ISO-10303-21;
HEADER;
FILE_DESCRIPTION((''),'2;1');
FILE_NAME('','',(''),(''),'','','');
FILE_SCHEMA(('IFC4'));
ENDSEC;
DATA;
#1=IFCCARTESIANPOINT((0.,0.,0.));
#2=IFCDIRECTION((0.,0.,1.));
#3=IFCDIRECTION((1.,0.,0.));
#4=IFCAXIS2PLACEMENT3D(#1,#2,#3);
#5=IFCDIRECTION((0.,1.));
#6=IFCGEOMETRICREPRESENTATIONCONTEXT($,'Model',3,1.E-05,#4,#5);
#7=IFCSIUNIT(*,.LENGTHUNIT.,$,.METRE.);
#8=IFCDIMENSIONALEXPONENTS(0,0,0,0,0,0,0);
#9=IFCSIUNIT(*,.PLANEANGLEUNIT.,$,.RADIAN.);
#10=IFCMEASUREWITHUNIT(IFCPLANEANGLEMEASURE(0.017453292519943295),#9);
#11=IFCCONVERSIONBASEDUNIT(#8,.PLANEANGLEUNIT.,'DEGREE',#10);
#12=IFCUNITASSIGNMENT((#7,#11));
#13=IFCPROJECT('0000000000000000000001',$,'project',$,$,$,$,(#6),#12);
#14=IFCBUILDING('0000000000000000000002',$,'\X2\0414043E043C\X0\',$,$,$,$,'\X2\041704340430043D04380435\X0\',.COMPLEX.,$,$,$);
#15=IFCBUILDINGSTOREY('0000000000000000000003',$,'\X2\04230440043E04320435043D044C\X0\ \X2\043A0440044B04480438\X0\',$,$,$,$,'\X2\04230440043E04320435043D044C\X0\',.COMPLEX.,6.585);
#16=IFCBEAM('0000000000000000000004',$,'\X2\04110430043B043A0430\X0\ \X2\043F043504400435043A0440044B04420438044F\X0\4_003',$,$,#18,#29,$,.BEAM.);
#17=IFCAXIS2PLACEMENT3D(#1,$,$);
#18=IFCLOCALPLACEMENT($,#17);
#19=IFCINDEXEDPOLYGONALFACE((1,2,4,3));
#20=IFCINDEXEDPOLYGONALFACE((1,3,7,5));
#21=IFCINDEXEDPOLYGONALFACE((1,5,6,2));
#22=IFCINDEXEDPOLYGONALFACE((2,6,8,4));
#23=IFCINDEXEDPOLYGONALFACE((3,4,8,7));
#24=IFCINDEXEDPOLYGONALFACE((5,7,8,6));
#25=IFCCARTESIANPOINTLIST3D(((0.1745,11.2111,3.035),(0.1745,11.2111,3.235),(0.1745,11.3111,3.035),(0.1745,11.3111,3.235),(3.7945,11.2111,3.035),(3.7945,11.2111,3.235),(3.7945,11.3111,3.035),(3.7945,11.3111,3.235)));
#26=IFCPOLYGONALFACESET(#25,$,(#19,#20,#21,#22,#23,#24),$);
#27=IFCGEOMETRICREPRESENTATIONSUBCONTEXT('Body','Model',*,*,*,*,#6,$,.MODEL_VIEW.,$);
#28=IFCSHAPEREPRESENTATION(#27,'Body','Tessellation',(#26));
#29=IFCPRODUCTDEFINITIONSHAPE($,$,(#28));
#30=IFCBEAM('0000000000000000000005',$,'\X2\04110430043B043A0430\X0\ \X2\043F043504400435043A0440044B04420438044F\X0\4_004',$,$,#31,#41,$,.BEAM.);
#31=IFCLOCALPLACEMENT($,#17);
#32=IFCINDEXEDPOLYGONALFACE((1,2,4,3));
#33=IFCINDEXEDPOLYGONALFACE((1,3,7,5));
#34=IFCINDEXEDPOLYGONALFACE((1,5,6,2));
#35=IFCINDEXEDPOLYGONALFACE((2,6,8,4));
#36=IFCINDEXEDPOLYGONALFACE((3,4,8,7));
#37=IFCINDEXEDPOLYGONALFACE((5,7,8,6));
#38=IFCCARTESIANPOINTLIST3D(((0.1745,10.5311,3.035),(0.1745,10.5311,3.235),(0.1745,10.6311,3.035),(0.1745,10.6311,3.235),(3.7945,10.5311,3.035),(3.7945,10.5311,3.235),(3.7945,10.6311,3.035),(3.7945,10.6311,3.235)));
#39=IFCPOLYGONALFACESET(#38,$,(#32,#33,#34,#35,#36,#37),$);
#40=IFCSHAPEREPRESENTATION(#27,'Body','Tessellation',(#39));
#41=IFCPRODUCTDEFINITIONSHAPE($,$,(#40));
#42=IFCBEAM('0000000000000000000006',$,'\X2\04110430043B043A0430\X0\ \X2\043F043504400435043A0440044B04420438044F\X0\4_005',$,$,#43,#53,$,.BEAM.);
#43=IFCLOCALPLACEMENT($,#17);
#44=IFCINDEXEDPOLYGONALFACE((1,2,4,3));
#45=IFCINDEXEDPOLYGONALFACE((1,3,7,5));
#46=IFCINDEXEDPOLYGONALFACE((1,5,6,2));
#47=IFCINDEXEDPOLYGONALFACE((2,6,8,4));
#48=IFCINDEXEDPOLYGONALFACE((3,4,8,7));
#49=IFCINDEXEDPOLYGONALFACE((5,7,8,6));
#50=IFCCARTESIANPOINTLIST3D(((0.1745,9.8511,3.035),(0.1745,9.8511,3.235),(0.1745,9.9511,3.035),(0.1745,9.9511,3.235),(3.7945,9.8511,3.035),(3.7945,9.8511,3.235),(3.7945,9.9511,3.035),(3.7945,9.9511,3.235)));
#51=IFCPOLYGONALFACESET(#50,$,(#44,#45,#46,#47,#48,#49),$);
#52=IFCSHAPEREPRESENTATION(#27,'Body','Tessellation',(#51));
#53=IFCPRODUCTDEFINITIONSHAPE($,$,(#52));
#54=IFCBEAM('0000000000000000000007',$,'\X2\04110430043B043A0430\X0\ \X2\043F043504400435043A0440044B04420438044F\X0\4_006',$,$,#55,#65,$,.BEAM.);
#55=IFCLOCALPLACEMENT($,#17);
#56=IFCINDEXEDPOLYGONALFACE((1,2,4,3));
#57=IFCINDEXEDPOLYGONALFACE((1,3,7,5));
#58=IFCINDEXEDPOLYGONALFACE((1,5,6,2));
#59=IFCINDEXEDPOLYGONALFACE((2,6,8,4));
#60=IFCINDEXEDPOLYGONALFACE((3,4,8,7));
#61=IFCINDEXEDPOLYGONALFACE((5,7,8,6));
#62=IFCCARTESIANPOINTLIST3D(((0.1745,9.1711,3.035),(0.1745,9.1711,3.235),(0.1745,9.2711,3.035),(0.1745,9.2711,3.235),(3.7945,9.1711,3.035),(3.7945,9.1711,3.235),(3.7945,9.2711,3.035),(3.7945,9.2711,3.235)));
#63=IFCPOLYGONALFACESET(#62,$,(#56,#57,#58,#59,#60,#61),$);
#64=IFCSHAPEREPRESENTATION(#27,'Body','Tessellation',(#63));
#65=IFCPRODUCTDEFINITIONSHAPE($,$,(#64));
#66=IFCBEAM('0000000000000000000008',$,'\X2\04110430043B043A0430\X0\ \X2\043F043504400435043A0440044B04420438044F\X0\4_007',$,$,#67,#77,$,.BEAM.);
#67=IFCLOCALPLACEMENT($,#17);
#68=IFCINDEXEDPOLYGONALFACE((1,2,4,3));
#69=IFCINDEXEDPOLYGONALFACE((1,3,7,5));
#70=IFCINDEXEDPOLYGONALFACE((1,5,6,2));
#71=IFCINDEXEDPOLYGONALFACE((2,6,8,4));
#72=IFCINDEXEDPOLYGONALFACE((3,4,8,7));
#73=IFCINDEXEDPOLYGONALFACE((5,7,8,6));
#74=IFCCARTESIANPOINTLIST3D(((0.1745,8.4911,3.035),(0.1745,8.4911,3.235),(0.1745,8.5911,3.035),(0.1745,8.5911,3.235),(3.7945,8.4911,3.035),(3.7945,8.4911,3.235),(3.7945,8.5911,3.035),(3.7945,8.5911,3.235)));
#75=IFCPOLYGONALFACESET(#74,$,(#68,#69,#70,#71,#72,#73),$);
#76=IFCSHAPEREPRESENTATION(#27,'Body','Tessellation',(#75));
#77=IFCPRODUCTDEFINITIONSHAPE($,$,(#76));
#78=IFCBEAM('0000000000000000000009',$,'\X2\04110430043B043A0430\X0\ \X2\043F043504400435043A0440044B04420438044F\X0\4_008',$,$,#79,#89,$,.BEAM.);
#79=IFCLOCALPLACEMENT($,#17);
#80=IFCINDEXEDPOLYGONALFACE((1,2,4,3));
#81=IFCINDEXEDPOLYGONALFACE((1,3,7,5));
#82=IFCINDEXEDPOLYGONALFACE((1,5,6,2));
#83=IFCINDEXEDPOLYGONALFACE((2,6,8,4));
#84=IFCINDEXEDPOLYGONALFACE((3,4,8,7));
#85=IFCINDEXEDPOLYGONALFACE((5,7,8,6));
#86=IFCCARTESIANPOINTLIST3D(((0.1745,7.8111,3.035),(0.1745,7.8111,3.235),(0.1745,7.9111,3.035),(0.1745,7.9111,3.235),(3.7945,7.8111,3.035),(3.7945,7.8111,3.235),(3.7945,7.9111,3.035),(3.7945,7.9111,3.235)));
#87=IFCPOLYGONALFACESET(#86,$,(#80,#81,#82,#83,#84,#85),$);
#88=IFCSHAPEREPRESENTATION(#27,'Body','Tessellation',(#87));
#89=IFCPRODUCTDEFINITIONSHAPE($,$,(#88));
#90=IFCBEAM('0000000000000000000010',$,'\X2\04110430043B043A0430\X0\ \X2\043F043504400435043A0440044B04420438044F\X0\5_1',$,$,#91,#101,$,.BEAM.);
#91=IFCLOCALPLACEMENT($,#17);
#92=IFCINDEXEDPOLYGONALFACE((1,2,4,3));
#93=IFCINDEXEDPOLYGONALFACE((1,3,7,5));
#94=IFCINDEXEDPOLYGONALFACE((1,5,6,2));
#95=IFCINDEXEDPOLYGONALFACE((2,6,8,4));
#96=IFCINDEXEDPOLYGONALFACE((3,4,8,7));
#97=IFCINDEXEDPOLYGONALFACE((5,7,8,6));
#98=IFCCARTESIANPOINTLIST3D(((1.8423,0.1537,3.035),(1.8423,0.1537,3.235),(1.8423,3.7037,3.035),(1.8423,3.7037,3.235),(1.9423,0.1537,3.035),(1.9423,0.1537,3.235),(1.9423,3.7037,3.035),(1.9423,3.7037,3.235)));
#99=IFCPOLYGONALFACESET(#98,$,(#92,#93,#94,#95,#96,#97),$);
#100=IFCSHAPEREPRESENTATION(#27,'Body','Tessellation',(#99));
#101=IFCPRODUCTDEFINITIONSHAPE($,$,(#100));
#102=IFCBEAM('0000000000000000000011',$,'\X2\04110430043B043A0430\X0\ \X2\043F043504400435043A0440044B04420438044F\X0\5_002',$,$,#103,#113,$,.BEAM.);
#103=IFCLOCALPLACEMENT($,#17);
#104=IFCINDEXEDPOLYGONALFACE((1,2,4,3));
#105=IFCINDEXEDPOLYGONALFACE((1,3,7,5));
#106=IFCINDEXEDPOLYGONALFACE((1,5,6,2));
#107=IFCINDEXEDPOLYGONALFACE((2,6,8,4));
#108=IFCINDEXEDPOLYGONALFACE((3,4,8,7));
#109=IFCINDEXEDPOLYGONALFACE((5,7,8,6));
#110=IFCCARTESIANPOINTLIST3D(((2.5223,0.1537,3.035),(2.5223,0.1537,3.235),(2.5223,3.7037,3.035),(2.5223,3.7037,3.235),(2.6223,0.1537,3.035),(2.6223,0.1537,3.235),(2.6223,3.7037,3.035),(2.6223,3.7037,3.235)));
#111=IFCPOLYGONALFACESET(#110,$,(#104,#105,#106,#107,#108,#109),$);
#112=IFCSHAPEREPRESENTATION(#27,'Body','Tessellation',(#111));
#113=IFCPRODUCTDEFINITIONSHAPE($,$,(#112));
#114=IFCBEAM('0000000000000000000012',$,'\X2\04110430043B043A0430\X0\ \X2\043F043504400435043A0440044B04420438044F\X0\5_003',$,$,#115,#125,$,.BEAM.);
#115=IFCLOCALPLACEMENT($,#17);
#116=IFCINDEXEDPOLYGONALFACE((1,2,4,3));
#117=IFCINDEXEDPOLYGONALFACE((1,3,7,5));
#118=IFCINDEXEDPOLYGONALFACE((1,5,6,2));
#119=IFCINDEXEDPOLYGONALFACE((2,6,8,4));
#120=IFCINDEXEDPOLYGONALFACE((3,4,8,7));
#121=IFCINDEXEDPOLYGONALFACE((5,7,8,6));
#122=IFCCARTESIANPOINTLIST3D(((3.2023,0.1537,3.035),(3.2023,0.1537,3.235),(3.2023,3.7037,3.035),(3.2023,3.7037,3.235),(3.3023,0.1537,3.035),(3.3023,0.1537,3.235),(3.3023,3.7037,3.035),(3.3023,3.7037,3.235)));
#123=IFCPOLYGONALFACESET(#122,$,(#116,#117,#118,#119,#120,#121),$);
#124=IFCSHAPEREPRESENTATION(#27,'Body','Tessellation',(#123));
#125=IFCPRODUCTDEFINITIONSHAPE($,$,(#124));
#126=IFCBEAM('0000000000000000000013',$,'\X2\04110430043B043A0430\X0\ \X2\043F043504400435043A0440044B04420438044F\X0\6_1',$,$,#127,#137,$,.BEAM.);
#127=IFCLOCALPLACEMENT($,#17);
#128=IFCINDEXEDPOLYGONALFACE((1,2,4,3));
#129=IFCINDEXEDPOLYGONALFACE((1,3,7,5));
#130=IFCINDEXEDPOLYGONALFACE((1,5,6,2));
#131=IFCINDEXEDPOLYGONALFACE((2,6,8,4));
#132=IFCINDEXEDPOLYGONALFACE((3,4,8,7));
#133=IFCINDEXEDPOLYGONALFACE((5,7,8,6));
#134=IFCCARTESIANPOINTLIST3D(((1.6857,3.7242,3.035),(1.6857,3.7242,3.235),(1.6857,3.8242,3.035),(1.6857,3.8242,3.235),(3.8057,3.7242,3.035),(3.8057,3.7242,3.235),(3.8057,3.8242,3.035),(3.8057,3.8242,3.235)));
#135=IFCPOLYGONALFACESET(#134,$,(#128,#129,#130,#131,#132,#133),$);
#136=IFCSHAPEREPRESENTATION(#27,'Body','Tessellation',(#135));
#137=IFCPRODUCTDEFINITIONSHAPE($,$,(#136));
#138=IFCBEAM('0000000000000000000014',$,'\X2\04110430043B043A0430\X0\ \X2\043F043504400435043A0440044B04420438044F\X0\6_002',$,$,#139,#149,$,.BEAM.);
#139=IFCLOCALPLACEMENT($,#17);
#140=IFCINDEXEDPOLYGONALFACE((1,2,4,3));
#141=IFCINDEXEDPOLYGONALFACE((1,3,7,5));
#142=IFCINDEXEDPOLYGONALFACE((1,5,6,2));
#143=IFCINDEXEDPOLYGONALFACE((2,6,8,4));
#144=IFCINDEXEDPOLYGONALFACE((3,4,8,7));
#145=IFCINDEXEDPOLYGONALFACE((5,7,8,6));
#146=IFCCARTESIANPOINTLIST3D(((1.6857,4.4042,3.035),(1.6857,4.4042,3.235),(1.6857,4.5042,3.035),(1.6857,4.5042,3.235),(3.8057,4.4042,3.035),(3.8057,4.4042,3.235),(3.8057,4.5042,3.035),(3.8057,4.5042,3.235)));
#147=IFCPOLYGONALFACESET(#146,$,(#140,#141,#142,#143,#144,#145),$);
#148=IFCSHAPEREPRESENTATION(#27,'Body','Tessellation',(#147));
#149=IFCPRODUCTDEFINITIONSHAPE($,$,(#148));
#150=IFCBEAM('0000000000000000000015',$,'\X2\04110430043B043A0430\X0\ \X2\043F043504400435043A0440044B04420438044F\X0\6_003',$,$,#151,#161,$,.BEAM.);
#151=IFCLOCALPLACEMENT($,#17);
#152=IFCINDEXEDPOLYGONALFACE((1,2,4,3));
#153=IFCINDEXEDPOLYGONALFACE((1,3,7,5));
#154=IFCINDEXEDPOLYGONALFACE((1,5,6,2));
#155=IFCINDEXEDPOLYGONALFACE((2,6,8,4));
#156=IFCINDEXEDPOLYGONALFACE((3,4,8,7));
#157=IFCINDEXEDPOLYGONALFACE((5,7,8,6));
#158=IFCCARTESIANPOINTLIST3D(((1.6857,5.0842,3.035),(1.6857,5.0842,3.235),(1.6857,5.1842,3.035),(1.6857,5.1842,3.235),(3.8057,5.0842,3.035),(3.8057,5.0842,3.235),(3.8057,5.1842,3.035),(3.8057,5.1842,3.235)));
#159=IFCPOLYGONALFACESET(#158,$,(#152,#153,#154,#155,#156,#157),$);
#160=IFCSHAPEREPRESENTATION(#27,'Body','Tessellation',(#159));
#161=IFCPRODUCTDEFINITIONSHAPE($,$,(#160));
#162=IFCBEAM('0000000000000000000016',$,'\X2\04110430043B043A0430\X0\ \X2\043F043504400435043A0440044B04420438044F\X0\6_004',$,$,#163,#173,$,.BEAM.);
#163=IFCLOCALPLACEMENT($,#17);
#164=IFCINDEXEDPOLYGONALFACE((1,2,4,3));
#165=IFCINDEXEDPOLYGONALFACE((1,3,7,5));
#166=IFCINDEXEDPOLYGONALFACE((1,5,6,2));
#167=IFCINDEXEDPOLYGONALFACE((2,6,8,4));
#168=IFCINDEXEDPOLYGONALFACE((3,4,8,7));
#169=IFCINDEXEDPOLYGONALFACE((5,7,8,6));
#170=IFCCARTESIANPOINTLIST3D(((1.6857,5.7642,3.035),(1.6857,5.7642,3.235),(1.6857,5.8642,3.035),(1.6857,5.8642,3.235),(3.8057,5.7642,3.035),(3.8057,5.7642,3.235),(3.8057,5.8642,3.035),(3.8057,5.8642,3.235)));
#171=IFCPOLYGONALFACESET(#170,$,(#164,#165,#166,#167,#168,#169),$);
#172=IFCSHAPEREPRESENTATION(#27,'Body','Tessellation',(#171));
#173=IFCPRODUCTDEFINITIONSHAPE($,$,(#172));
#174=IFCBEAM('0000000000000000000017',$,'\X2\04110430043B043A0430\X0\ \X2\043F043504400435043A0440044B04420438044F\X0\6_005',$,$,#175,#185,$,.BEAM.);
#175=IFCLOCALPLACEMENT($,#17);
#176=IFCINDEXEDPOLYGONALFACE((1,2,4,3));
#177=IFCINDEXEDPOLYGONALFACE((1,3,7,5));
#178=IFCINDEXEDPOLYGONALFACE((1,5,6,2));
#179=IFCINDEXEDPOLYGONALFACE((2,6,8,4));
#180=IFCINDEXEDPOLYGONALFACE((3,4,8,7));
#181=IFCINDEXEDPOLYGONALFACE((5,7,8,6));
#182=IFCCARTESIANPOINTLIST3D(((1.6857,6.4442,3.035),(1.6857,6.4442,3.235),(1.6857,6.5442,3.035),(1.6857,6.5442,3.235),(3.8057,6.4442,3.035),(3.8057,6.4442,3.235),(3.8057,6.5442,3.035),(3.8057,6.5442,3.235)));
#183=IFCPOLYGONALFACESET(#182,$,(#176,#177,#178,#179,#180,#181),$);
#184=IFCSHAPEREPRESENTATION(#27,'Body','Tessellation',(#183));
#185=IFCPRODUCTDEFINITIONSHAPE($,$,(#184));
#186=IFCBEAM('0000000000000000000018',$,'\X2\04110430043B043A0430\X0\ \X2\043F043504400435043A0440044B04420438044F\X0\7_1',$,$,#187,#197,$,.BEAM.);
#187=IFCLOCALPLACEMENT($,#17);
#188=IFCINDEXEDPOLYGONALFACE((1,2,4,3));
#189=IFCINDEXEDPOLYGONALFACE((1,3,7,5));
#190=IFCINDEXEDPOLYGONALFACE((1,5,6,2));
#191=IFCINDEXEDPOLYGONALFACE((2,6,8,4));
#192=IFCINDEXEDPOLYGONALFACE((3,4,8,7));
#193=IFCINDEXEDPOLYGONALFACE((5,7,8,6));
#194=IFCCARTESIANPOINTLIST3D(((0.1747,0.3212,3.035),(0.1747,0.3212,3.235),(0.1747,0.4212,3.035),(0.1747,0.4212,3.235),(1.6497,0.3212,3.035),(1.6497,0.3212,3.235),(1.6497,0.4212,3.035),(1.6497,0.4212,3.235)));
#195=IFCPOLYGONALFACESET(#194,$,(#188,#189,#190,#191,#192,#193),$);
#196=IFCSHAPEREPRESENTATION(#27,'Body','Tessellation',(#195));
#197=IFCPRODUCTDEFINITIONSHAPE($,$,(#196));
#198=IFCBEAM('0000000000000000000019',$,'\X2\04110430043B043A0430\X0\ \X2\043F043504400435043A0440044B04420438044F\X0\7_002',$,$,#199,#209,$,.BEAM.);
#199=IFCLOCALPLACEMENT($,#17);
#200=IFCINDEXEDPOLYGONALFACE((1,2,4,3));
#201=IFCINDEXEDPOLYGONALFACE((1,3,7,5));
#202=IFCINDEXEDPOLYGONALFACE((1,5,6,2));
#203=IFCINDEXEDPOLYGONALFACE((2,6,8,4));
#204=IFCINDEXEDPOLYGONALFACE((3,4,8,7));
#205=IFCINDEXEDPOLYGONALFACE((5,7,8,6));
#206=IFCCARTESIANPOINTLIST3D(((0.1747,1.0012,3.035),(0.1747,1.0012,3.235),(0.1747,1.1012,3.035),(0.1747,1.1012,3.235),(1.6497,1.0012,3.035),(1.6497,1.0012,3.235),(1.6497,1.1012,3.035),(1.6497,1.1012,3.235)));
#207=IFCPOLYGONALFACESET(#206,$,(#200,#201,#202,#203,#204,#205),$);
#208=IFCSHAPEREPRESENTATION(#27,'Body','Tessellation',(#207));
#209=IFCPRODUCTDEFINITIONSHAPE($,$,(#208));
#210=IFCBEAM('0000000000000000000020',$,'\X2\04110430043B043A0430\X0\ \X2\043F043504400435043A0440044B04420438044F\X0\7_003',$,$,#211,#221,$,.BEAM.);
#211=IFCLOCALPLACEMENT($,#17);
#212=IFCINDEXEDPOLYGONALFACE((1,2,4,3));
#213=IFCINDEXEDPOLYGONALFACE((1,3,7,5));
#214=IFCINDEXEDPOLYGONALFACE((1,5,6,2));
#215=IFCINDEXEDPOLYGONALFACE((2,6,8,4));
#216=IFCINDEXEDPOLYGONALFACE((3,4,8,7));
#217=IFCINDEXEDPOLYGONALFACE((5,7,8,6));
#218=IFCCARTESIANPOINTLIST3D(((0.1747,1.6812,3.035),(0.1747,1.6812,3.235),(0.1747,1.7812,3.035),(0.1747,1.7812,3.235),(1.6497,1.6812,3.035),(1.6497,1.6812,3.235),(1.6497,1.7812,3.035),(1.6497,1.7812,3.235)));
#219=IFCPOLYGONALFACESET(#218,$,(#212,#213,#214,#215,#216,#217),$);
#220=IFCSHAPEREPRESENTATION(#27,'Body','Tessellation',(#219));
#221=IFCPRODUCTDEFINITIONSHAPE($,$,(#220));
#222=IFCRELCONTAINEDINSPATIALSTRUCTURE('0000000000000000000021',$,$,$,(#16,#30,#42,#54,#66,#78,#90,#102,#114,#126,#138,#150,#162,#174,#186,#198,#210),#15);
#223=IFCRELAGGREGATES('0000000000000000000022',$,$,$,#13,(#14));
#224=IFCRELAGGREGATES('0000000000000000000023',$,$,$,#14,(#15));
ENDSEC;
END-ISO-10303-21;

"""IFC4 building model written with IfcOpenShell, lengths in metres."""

from ifc_helpers import new_model, entity, si_unit, converted_unit, direction, frame, frame_2d, origin_with_axes, origin_2d_with_axis, place, context, subcontext, project, spatial, rectangle, extrude, element, save


model = new_model("IFC4")

# Units and contexts
model_context = context("Model", 3, precision=1e-05, world=origin_with_axes(), true_north=direction((0.0, 1.0)))
body_context = subcontext(model_context, "Body", "Model", "MODEL_VIEW")
ifc_project = project(units=[si_unit("LENGTHUNIT", "METRE"), converted_unit("PLANEANGLEUNIT", "DEGREE", entity("IfcPlaneAngleMeasure", 0.017453292519943295), si_unit("PLANEANGLEUNIT", "RADIAN"), dimensions=[0, 0, 0, 0, 0, 0, 0])], contexts=[model_context])

# Building, storey
building = spatial("IfcBuilding", under=ifc_project, Name="Дом", LongName="Здание", CompositionType="COMPLEX")
storey = spatial("IfcBuildingStorey", under=building, Name="Уровень крыши", LongName="Уровень", CompositionType="COMPLEX", Elevation=6.585)

# Beams
placement = place(None, origin_with_axes())
element("IfcBeam", 1, at=placement, inside=storey, Name="Балка перекрытия4_003", PredefinedType="BEAM", context=body_context, shape_type="SweptSolid", body=[
    extrude(rectangle(XDim=3.62, YDim=0.1, at=origin_2d_with_axis()), frame((1.9845, 11.2611, 3.035), z_axis=(0.0, 0.0, 1.0), x_axis=(1.0, 0.0, 0.0)), (0.0, 0.0, 1.0), 0.2),
])
element("IfcBeam", 2, at=placement, inside=storey, Name="Балка перекрытия4_004", PredefinedType="BEAM", context=body_context, shape_type="SweptSolid", body=[
    extrude(rectangle(XDim=3.62, YDim=0.1, at=origin_2d_with_axis()), frame((1.9845, 10.5811, 3.035), z_axis=(0.0, 0.0, 1.0), x_axis=(1.0, 0.0, 0.0)), (0.0, 0.0, 1.0), 0.2),
])
element("IfcBeam", 3, at=placement, inside=storey, Name="Балка перекрытия4_005", PredefinedType="BEAM", context=body_context, shape_type="SweptSolid", body=[
    extrude(rectangle(XDim=3.62, YDim=0.1, at=origin_2d_with_axis()), frame((1.9845, 9.9011, 3.035), z_axis=(0.0, 0.0, 1.0), x_axis=(1.0, 0.0, 0.0)), (0.0, 0.0, 1.0), 0.2),
])
element("IfcBeam", 4, at=placement, inside=storey, Name="Балка перекрытия4_006", PredefinedType="BEAM", context=body_context, shape_type="SweptSolid", body=[
    extrude(rectangle(XDim=3.62, YDim=0.1, at=origin_2d_with_axis()), frame((1.9845, 9.2211, 3.035), z_axis=(0.0, 0.0, 1.0), x_axis=(1.0, 0.0, 0.0)), (0.0, 0.0, 1.0), 0.2),
])
element("IfcBeam", 5, at=placement, inside=storey, Name="Балка перекрытия4_007", PredefinedType="BEAM", context=body_context, shape_type="SweptSolid", body=[
    extrude(rectangle(XDim=3.62, YDim=0.1, at=origin_2d_with_axis()), frame((1.9845, 8.5411, 3.035), z_axis=(0.0, 0.0, 1.0), x_axis=(1.0, 0.0, 0.0)), (0.0, 0.0, 1.0), 0.2),
])
element("IfcBeam", 6, at=placement, inside=storey, Name="Балка перекрытия4_008", PredefinedType="BEAM", context=body_context, shape_type="SweptSolid", body=[
    extrude(rectangle(XDim=3.62, YDim=0.1, at=origin_2d_with_axis()), frame((1.9845, 7.8611, 3.035), z_axis=(0.0, 0.0, 1.0), x_axis=(1.0, 0.0, 0.0)), (0.0, 0.0, 1.0), 0.2),
])
element("IfcBeam", 7, at=placement, inside=storey, Name="Балка перекрытия5_1", PredefinedType="BEAM", context=body_context, shape_type="SweptSolid", body=[
    extrude(rectangle(XDim=0.1, YDim=3.55, at=frame_2d((0.0, 0.0), x_axis=(1.0, 0.0))), frame((1.8923, 1.9287, 3.035), z_axis=(0.0, 0.0, 1.0), x_axis=(1.0, 0.0, 0.0)), (0.0, 0.0, 1.0), 0.2),
])
element("IfcBeam", 8, at=placement, inside=storey, Name="Балка перекрытия5_002", PredefinedType="BEAM", context=body_context, shape_type="SweptSolid", body=[
    extrude(rectangle(XDim=0.1, YDim=3.55, at=frame_2d((0.0, 0.0), x_axis=(1.0, 0.0))), frame((2.5723, 1.9287, 3.035), z_axis=(0.0, 0.0, 1.0), x_axis=(1.0, 0.0, 0.0)), (0.0, 0.0, 1.0), 0.2),
])
element("IfcBeam", 9, at=placement, inside=storey, Name="Балка перекрытия5_003", PredefinedType="BEAM", context=body_context, shape_type="SweptSolid", body=[
    extrude(rectangle(XDim=0.1, YDim=3.55, at=frame_2d((0.0, 0.0), x_axis=(1.0, 0.0))), frame((3.2523, 1.9287, 3.035), z_axis=(0.0, 0.0, 1.0), x_axis=(1.0, 0.0, 0.0)), (0.0, 0.0, 1.0), 0.2),
])
element("IfcBeam", 10, at=placement, inside=storey, Name="Балка перекрытия6_1", PredefinedType="BEAM", context=body_context, shape_type="SweptSolid", body=[
    extrude(rectangle(XDim=2.12, YDim=0.1, at=origin_2d_with_axis()), frame((2.7457, 3.7742, 3.035), z_axis=(0.0, 0.0, 1.0), x_axis=(1.0, 0.0, 0.0)), (0.0, 0.0, 1.0), 0.2),
])
element("IfcBeam", 11, at=placement, inside=storey, Name="Балка перекрытия6_002", PredefinedType="BEAM", context=body_context, shape_type="SweptSolid", body=[
    extrude(rectangle(XDim=2.12, YDim=0.1, at=origin_2d_with_axis()), frame((2.7457, 4.4542, 3.035), z_axis=(0.0, 0.0, 1.0), x_axis=(1.0, 0.0, 0.0)), (0.0, 0.0, 1.0), 0.2),
])
element("IfcBeam", 12, at=placement, inside=storey, Name="Балка перекрытия6_003", PredefinedType="BEAM", context=body_context, shape_type="SweptSolid", body=[
    extrude(rectangle(XDim=2.12, YDim=0.1, at=origin_2d_with_axis()), frame((2.7457, 5.1342, 3.035), z_axis=(0.0, 0.0, 1.0), x_axis=(1.0, 0.0, 0.0)), (0.0, 0.0, 1.0), 0.2),
])
element("IfcBeam", 13, at=placement, inside=storey, Name="Балка перекрытия6_004", PredefinedType="BEAM", context=body_context, shape_type="SweptSolid", body=[
    extrude(rectangle(XDim=2.12, YDim=0.1, at=origin_2d_with_axis()), frame((2.7457, 5.8142, 3.035), z_axis=(0.0, 0.0, 1.0), x_axis=(1.0, 0.0, 0.0)), (0.0, 0.0, 1.0), 0.2),
])
element("IfcBeam", 14, at=placement, inside=storey, Name="Балка перекрытия6_005", PredefinedType="BEAM", context=body_context, shape_type="SweptSolid", body=[
    extrude(rectangle(XDim=2.12, YDim=0.1, at=origin_2d_with_axis()), frame((2.7457, 6.4942, 3.035), z_axis=(0.0, 0.0, 1.0), x_axis=(1.0, 0.0, 0.0)), (0.0, 0.0, 1.0), 0.2),
])
element("IfcBeam", 15, at=placement, inside=storey, Name="Балка перекрытия7_1", PredefinedType="BEAM", context=body_context, shape_type="SweptSolid", body=[
    extrude(rectangle(XDim=1.475, YDim=0.1, at=origin_2d_with_axis()), frame((0.9122, 0.3712, 3.035), z_axis=(0.0, 0.0, 1.0), x_axis=(1.0, 0.0, 0.0)), (0.0, 0.0, 1.0), 0.2),
])
element("IfcBeam", 16, at=placement, inside=storey, Name="Балка перекрытия7_002", PredefinedType="BEAM", context=body_context, shape_type="SweptSolid", body=[
    extrude(rectangle(XDim=1.475, YDim=0.1, at=origin_2d_with_axis()), frame((0.9122, 1.0512, 3.035), z_axis=(0.0, 0.0, 1.0), x_axis=(1.0, 0.0, 0.0)), (0.0, 0.0, 1.0), 0.2),
])
element("IfcBeam", 17, at=placement, inside=storey, Name="Балка перекрытия7_003", PredefinedType="BEAM", context=body_context, shape_type="SweptSolid", body=[
    extrude(rectangle(XDim=1.475, YDim=0.1, at=origin_2d_with_axis()), frame((0.9122, 1.7312, 3.035), z_axis=(0.0, 0.0, 1.0), x_axis=(1.0, 0.0, 0.0)), (0.0, 0.0, 1.0), 0.2),
])

save(model, "model.ifc")
